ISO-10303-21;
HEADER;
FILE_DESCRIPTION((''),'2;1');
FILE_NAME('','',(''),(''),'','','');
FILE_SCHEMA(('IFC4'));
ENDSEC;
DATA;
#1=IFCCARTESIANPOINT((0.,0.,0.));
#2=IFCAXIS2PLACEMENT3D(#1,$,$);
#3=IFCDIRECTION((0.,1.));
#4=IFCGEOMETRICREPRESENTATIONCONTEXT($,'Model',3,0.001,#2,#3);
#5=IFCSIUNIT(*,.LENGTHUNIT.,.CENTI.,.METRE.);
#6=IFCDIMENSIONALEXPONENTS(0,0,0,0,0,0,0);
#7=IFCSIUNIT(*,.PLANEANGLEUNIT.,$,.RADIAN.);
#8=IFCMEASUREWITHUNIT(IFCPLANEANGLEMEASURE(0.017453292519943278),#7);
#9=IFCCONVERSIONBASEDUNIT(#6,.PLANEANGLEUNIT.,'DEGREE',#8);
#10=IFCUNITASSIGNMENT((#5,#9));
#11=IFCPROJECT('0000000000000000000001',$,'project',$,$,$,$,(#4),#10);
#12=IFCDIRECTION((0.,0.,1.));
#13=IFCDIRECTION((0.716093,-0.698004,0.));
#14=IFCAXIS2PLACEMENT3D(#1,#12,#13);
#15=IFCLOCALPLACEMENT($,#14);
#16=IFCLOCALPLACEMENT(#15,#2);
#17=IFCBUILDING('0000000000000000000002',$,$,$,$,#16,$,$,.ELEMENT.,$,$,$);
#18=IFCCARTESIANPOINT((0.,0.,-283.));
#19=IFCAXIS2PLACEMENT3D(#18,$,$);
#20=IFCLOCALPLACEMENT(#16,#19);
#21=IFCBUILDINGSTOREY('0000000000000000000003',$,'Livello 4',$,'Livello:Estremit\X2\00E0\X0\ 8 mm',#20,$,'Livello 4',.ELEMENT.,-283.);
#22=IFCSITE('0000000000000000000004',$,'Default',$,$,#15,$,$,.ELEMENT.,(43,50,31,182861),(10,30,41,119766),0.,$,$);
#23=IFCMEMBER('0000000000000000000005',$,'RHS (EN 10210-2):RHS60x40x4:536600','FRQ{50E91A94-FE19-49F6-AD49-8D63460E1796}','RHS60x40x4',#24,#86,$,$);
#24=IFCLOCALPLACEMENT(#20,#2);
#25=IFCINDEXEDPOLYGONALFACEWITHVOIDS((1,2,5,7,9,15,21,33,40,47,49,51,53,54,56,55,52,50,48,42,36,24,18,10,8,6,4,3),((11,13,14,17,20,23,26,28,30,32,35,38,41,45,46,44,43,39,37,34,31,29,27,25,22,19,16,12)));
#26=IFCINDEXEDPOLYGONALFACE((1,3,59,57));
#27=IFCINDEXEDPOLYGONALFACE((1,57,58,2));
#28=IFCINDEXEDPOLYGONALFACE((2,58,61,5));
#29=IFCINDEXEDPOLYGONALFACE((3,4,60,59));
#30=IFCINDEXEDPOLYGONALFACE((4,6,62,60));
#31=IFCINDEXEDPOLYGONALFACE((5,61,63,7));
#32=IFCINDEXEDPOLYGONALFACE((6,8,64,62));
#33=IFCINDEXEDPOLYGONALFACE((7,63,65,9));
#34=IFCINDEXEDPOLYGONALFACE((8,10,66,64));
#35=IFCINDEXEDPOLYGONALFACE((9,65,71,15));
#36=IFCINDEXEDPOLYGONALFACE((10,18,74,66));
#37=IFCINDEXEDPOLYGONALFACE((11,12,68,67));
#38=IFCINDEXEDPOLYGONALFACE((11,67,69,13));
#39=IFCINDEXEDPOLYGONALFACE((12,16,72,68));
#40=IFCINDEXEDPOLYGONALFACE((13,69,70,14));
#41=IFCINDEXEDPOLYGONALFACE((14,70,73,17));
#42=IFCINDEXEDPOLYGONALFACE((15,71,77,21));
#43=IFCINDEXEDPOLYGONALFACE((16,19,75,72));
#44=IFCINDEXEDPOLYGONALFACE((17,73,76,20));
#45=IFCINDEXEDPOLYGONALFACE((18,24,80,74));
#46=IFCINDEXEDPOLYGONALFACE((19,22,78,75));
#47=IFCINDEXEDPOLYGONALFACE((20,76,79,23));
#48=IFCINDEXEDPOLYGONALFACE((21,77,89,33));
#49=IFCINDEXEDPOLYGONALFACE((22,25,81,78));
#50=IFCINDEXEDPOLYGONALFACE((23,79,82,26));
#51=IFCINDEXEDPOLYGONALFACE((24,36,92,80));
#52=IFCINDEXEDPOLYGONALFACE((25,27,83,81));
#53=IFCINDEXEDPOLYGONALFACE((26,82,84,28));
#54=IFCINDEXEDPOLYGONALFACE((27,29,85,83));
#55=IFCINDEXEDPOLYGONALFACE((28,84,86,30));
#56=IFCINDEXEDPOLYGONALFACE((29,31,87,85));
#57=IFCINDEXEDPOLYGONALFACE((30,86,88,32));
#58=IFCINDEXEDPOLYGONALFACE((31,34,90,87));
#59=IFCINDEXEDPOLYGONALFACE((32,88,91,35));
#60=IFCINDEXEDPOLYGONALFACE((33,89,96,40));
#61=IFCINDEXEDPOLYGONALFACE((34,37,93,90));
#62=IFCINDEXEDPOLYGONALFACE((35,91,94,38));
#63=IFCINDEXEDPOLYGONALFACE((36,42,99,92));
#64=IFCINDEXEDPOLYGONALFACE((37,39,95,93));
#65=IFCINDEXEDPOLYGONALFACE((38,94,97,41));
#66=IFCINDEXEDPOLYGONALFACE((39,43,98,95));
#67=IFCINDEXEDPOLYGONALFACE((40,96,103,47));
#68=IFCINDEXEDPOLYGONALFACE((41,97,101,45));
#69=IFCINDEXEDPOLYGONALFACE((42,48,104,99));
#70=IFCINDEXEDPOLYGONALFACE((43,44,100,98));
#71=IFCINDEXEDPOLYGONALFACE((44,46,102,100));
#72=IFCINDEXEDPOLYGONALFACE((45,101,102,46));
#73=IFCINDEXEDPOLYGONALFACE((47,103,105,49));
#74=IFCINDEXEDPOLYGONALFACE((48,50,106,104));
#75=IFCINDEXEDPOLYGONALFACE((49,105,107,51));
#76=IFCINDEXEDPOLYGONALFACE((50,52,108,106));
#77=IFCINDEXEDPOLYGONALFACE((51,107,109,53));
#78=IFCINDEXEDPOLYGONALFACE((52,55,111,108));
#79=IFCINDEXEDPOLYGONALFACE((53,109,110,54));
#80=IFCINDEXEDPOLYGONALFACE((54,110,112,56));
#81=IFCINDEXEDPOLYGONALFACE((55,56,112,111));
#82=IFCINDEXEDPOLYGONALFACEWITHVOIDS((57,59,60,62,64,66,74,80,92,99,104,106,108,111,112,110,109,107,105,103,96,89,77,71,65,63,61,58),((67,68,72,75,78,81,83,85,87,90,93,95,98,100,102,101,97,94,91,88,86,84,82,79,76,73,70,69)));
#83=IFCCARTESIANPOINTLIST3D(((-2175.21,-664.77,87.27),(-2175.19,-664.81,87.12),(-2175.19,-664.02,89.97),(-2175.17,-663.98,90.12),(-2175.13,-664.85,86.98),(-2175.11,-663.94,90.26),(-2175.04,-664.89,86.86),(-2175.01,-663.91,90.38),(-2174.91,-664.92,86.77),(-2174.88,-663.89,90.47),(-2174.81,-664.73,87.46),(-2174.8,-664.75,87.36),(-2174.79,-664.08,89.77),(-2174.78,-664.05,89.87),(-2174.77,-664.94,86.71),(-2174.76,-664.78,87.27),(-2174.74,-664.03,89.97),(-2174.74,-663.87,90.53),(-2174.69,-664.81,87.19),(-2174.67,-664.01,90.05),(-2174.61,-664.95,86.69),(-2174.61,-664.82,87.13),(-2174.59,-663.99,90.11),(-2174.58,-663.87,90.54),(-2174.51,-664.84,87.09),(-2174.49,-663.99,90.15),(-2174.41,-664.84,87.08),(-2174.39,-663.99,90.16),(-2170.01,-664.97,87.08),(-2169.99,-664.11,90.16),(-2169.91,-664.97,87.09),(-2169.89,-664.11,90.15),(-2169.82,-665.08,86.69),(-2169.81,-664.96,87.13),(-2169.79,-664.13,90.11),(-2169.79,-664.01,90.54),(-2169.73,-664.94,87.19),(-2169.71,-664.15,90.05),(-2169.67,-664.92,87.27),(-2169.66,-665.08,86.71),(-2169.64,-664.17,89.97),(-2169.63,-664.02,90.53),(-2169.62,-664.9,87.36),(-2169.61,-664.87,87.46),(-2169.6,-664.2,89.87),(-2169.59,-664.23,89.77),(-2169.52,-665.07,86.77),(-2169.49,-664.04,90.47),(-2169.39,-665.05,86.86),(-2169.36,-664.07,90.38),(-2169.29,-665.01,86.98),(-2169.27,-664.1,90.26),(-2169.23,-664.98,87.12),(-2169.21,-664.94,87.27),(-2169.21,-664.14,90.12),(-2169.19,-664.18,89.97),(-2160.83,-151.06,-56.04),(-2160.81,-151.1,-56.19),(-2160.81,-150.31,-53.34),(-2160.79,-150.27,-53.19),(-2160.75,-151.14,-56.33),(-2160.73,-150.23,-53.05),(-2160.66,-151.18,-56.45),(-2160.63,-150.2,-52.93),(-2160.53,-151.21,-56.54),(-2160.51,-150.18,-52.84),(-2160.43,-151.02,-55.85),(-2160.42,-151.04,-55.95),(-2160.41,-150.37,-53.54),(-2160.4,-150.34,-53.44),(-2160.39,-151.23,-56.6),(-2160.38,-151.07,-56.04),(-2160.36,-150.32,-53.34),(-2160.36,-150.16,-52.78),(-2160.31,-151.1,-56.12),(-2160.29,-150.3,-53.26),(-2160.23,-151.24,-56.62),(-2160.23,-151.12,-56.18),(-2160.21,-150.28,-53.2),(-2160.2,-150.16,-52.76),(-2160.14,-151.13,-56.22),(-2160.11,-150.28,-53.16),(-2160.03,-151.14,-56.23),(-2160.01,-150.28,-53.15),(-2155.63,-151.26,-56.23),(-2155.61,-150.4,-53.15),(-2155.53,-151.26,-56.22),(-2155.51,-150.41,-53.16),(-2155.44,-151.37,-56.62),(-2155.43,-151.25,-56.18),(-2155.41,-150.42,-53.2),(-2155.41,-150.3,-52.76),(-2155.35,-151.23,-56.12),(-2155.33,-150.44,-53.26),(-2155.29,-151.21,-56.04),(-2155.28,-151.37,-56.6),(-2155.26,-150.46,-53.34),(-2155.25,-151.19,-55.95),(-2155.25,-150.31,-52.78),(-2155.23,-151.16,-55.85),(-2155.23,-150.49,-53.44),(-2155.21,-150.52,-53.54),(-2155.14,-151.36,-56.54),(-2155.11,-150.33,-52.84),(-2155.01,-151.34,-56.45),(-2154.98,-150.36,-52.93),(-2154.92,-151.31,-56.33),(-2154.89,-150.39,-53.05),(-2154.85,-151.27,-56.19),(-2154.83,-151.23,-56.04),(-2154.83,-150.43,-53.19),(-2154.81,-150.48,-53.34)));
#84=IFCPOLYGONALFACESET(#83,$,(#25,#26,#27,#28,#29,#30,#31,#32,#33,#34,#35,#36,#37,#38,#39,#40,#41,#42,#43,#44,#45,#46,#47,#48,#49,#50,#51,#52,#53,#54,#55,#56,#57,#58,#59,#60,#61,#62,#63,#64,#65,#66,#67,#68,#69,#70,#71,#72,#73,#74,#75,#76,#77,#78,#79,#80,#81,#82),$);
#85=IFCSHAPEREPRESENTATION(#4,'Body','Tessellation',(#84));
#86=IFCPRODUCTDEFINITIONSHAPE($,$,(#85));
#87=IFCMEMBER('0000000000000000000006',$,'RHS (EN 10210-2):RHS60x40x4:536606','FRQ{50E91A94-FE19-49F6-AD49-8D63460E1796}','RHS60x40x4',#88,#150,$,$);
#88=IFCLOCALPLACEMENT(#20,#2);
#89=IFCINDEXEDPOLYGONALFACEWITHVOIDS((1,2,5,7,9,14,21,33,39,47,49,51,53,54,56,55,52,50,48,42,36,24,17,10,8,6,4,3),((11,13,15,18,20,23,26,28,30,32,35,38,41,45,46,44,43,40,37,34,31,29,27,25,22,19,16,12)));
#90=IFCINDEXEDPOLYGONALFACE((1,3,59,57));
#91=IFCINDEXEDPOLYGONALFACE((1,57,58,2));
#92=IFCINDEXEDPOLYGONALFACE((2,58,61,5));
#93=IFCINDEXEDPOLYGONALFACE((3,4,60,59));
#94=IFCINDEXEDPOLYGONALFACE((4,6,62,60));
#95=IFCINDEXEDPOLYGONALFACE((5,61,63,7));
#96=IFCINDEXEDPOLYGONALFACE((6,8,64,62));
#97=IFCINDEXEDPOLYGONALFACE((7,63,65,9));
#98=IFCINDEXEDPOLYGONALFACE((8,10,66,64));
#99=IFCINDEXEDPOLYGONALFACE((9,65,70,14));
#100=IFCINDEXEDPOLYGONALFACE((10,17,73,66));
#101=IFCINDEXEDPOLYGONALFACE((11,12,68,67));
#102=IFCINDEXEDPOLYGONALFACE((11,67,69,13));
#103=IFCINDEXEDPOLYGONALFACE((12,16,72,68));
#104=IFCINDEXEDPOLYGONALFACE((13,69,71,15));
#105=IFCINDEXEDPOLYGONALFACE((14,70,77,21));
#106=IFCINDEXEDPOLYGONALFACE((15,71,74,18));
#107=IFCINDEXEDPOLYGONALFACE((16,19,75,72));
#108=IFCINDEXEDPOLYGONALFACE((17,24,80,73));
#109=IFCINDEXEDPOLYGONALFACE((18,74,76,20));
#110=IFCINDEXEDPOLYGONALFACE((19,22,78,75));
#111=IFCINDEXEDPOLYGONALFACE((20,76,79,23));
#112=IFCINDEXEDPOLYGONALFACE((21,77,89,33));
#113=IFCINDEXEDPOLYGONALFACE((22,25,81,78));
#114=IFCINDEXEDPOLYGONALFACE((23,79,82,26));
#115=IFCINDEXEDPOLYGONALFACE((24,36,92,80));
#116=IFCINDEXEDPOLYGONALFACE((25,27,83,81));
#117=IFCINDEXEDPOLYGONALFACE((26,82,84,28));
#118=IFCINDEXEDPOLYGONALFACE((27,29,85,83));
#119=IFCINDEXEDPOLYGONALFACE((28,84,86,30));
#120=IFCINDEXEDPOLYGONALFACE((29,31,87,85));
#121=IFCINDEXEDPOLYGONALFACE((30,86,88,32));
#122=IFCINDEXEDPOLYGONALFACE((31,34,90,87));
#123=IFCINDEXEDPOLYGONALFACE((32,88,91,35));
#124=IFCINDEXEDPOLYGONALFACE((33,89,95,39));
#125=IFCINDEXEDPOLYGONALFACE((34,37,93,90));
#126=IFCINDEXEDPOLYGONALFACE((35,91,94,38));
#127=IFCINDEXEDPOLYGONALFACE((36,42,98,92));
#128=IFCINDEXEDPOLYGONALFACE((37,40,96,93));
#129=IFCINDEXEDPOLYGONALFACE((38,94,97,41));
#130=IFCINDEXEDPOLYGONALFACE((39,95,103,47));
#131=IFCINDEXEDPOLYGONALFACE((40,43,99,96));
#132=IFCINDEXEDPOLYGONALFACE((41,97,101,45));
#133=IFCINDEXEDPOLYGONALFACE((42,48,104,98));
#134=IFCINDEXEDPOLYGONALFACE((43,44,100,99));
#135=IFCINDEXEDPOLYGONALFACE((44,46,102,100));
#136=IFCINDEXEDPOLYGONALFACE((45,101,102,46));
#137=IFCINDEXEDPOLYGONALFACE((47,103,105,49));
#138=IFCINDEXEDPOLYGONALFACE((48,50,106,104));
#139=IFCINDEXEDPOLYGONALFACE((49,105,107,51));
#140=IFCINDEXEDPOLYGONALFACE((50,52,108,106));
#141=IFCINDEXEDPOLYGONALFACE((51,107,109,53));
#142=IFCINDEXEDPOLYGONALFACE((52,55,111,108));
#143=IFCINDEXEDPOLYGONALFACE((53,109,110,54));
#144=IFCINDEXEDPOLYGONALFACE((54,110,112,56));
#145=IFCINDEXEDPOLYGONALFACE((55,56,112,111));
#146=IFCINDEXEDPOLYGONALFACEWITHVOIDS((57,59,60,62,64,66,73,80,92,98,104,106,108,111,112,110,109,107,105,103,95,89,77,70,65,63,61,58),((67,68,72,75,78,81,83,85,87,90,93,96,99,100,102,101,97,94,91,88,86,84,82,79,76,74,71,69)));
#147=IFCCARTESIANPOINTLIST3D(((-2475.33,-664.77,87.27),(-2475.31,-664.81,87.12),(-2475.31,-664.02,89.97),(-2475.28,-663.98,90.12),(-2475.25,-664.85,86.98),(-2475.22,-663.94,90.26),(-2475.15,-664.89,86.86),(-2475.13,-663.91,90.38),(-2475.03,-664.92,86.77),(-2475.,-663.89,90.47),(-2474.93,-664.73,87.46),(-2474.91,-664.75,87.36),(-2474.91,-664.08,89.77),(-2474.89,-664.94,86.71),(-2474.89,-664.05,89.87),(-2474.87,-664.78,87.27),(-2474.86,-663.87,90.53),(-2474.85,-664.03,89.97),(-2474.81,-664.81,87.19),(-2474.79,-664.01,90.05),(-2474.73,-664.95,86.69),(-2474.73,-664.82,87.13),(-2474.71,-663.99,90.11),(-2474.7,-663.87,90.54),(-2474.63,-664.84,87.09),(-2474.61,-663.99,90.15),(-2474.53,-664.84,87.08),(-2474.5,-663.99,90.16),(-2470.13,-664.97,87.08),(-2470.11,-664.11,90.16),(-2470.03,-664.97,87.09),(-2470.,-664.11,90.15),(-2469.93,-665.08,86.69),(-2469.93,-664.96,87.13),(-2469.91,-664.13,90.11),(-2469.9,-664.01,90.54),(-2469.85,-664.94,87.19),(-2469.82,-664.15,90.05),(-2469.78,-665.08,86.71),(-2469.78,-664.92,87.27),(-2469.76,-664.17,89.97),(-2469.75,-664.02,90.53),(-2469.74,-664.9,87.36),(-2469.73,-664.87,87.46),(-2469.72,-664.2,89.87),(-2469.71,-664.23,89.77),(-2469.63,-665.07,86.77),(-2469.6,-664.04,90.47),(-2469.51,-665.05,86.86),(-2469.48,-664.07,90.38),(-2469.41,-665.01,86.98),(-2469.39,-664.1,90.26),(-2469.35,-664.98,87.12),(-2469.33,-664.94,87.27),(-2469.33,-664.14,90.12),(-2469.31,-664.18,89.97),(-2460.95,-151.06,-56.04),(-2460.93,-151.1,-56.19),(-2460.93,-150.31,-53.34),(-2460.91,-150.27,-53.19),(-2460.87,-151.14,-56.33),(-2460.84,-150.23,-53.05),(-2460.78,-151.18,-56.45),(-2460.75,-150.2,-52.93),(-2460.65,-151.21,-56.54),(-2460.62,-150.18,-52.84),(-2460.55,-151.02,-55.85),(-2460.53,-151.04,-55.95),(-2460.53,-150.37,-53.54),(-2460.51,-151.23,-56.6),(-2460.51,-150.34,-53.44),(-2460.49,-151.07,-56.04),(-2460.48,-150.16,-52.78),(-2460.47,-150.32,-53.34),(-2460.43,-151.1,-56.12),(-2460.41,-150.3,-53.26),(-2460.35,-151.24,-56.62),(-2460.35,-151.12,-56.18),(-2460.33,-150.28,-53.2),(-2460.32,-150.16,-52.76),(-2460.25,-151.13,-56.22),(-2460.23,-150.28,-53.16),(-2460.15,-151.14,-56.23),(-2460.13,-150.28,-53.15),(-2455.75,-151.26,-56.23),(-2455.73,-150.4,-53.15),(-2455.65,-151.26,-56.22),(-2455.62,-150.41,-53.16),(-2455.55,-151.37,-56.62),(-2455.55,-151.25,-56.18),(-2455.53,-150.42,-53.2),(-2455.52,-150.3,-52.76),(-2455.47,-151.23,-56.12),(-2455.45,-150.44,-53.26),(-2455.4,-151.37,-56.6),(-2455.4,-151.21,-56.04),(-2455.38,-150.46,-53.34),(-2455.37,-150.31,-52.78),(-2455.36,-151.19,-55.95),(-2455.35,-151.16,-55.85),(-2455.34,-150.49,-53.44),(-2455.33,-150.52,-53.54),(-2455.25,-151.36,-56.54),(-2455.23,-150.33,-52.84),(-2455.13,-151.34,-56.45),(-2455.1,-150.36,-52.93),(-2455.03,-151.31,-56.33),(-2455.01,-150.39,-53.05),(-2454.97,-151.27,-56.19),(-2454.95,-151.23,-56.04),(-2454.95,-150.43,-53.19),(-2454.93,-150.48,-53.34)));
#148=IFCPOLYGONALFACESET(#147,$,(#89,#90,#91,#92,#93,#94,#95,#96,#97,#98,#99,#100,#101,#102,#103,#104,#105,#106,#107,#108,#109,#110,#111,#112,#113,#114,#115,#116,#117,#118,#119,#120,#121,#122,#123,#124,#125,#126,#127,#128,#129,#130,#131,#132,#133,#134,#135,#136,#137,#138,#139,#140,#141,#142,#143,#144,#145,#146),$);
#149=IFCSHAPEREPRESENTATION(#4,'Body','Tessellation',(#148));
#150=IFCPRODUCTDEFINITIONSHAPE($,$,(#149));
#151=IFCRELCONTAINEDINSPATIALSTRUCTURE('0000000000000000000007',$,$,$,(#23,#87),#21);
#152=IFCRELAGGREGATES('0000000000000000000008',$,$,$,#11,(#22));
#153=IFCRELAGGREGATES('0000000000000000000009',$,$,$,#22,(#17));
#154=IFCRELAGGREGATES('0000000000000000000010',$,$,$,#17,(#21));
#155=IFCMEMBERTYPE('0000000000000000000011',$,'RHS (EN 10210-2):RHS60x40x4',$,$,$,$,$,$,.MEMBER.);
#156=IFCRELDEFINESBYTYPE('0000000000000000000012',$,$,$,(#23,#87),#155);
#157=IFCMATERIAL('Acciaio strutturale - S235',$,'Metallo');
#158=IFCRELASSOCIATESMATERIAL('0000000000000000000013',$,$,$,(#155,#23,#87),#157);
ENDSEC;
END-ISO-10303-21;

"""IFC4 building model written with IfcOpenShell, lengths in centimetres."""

from ifc_helpers import new_model, entity, si_unit, converted_unit, direction, frame, origin, origin_2d, place, context, project, spatial, hollow_rectangle, extrude, material, type_object, element, save


model = new_model("IFC4")

# Units and contexts
model_context = context("Model", 3, precision=0.001, world=origin(), true_north=direction((0.0, 1.0)))
ifc_project = project(units=[si_unit("LENGTHUNIT", "METRE", prefix="CENTI"), converted_unit("PLANEANGLEUNIT", "DEGREE", entity("IfcPlaneAngleMeasure", 0.017453292519943278), si_unit("PLANEANGLEUNIT", "RADIAN"), dimensions=[0, 0, 0, 0, 0, 0, 0])], contexts=[model_context])

# Site, building, storey
site_placement = place(None, frame((0.0, 0.0, 0.0), z_axis=(0.0, 0.0, 1.0), x_axis=(0.716093, -0.698004, 0.0)))
site = spatial("IfcSite", under=ifc_project, at=site_placement, Name="Default", CompositionType="ELEMENT", RefLatitude=(43, 50, 31, 182861), RefLongitude=(10, 30, 41, 119766), RefElevation=0.0)
building_placement = place(site_placement, origin())
building = spatial("IfcBuilding", under=site, at=building_placement, CompositionType="ELEMENT")
storey_placement = place(building_placement, frame((0.0, 0.0, -283.0)))
storey = spatial("IfcBuildingStorey", under=building, at=storey_placement, Name="Livello 4", ObjectType="Livello:Estremità 8 mm", LongName="Livello 4", CompositionType="ELEMENT", Elevation=-283.0)

# Shared definitions
ifc_material = material(Name="Acciaio strutturale - S235", Category="Metallo")

# Members
member_type = type_object("IfcMemberType", Name="RHS (EN 10210-2):RHS60x40x4", PredefinedType="MEMBER", material=ifc_material)
for number, where, z_axis, x_axis, name in (
    (1, (-2172.2, -664.48, 88.62), (-0.026952, -0.962871, 0.268612), (0.007516, 0.268507, 0.963248), "RHS (EN 10210-2):RHS60x40x4:536600"),
    (2, (-2472.32, -664.48, 88.62), (-0.026952, -0.962871, 0.268612), (0.007516, 0.268507, 0.963248), "RHS (EN 10210-2):RHS60x40x4:536606"),
):
    element("IfcMember", number, at=place(storey_placement, frame(where, z_axis=z_axis, x_axis=x_axis)), inside=storey, type_object=member_type, material=ifc_material, Name=name, Description="FRQ{50E91A94-FE19-49F6-AD49-8D63460E1796}", ObjectType="RHS60x40x4", context=model_context, shape_type="SweptSolid", body=[
        extrude(hollow_rectangle(XDim=4.0, YDim=6.0, WallThickness=0.4, InnerFilletRadius=0.4, OuterFilletRadius=0.6, at=origin_2d()), origin(), (0.0, 0.0, -1.0), 533.52),
    ])

save(model, "model.ifc")
